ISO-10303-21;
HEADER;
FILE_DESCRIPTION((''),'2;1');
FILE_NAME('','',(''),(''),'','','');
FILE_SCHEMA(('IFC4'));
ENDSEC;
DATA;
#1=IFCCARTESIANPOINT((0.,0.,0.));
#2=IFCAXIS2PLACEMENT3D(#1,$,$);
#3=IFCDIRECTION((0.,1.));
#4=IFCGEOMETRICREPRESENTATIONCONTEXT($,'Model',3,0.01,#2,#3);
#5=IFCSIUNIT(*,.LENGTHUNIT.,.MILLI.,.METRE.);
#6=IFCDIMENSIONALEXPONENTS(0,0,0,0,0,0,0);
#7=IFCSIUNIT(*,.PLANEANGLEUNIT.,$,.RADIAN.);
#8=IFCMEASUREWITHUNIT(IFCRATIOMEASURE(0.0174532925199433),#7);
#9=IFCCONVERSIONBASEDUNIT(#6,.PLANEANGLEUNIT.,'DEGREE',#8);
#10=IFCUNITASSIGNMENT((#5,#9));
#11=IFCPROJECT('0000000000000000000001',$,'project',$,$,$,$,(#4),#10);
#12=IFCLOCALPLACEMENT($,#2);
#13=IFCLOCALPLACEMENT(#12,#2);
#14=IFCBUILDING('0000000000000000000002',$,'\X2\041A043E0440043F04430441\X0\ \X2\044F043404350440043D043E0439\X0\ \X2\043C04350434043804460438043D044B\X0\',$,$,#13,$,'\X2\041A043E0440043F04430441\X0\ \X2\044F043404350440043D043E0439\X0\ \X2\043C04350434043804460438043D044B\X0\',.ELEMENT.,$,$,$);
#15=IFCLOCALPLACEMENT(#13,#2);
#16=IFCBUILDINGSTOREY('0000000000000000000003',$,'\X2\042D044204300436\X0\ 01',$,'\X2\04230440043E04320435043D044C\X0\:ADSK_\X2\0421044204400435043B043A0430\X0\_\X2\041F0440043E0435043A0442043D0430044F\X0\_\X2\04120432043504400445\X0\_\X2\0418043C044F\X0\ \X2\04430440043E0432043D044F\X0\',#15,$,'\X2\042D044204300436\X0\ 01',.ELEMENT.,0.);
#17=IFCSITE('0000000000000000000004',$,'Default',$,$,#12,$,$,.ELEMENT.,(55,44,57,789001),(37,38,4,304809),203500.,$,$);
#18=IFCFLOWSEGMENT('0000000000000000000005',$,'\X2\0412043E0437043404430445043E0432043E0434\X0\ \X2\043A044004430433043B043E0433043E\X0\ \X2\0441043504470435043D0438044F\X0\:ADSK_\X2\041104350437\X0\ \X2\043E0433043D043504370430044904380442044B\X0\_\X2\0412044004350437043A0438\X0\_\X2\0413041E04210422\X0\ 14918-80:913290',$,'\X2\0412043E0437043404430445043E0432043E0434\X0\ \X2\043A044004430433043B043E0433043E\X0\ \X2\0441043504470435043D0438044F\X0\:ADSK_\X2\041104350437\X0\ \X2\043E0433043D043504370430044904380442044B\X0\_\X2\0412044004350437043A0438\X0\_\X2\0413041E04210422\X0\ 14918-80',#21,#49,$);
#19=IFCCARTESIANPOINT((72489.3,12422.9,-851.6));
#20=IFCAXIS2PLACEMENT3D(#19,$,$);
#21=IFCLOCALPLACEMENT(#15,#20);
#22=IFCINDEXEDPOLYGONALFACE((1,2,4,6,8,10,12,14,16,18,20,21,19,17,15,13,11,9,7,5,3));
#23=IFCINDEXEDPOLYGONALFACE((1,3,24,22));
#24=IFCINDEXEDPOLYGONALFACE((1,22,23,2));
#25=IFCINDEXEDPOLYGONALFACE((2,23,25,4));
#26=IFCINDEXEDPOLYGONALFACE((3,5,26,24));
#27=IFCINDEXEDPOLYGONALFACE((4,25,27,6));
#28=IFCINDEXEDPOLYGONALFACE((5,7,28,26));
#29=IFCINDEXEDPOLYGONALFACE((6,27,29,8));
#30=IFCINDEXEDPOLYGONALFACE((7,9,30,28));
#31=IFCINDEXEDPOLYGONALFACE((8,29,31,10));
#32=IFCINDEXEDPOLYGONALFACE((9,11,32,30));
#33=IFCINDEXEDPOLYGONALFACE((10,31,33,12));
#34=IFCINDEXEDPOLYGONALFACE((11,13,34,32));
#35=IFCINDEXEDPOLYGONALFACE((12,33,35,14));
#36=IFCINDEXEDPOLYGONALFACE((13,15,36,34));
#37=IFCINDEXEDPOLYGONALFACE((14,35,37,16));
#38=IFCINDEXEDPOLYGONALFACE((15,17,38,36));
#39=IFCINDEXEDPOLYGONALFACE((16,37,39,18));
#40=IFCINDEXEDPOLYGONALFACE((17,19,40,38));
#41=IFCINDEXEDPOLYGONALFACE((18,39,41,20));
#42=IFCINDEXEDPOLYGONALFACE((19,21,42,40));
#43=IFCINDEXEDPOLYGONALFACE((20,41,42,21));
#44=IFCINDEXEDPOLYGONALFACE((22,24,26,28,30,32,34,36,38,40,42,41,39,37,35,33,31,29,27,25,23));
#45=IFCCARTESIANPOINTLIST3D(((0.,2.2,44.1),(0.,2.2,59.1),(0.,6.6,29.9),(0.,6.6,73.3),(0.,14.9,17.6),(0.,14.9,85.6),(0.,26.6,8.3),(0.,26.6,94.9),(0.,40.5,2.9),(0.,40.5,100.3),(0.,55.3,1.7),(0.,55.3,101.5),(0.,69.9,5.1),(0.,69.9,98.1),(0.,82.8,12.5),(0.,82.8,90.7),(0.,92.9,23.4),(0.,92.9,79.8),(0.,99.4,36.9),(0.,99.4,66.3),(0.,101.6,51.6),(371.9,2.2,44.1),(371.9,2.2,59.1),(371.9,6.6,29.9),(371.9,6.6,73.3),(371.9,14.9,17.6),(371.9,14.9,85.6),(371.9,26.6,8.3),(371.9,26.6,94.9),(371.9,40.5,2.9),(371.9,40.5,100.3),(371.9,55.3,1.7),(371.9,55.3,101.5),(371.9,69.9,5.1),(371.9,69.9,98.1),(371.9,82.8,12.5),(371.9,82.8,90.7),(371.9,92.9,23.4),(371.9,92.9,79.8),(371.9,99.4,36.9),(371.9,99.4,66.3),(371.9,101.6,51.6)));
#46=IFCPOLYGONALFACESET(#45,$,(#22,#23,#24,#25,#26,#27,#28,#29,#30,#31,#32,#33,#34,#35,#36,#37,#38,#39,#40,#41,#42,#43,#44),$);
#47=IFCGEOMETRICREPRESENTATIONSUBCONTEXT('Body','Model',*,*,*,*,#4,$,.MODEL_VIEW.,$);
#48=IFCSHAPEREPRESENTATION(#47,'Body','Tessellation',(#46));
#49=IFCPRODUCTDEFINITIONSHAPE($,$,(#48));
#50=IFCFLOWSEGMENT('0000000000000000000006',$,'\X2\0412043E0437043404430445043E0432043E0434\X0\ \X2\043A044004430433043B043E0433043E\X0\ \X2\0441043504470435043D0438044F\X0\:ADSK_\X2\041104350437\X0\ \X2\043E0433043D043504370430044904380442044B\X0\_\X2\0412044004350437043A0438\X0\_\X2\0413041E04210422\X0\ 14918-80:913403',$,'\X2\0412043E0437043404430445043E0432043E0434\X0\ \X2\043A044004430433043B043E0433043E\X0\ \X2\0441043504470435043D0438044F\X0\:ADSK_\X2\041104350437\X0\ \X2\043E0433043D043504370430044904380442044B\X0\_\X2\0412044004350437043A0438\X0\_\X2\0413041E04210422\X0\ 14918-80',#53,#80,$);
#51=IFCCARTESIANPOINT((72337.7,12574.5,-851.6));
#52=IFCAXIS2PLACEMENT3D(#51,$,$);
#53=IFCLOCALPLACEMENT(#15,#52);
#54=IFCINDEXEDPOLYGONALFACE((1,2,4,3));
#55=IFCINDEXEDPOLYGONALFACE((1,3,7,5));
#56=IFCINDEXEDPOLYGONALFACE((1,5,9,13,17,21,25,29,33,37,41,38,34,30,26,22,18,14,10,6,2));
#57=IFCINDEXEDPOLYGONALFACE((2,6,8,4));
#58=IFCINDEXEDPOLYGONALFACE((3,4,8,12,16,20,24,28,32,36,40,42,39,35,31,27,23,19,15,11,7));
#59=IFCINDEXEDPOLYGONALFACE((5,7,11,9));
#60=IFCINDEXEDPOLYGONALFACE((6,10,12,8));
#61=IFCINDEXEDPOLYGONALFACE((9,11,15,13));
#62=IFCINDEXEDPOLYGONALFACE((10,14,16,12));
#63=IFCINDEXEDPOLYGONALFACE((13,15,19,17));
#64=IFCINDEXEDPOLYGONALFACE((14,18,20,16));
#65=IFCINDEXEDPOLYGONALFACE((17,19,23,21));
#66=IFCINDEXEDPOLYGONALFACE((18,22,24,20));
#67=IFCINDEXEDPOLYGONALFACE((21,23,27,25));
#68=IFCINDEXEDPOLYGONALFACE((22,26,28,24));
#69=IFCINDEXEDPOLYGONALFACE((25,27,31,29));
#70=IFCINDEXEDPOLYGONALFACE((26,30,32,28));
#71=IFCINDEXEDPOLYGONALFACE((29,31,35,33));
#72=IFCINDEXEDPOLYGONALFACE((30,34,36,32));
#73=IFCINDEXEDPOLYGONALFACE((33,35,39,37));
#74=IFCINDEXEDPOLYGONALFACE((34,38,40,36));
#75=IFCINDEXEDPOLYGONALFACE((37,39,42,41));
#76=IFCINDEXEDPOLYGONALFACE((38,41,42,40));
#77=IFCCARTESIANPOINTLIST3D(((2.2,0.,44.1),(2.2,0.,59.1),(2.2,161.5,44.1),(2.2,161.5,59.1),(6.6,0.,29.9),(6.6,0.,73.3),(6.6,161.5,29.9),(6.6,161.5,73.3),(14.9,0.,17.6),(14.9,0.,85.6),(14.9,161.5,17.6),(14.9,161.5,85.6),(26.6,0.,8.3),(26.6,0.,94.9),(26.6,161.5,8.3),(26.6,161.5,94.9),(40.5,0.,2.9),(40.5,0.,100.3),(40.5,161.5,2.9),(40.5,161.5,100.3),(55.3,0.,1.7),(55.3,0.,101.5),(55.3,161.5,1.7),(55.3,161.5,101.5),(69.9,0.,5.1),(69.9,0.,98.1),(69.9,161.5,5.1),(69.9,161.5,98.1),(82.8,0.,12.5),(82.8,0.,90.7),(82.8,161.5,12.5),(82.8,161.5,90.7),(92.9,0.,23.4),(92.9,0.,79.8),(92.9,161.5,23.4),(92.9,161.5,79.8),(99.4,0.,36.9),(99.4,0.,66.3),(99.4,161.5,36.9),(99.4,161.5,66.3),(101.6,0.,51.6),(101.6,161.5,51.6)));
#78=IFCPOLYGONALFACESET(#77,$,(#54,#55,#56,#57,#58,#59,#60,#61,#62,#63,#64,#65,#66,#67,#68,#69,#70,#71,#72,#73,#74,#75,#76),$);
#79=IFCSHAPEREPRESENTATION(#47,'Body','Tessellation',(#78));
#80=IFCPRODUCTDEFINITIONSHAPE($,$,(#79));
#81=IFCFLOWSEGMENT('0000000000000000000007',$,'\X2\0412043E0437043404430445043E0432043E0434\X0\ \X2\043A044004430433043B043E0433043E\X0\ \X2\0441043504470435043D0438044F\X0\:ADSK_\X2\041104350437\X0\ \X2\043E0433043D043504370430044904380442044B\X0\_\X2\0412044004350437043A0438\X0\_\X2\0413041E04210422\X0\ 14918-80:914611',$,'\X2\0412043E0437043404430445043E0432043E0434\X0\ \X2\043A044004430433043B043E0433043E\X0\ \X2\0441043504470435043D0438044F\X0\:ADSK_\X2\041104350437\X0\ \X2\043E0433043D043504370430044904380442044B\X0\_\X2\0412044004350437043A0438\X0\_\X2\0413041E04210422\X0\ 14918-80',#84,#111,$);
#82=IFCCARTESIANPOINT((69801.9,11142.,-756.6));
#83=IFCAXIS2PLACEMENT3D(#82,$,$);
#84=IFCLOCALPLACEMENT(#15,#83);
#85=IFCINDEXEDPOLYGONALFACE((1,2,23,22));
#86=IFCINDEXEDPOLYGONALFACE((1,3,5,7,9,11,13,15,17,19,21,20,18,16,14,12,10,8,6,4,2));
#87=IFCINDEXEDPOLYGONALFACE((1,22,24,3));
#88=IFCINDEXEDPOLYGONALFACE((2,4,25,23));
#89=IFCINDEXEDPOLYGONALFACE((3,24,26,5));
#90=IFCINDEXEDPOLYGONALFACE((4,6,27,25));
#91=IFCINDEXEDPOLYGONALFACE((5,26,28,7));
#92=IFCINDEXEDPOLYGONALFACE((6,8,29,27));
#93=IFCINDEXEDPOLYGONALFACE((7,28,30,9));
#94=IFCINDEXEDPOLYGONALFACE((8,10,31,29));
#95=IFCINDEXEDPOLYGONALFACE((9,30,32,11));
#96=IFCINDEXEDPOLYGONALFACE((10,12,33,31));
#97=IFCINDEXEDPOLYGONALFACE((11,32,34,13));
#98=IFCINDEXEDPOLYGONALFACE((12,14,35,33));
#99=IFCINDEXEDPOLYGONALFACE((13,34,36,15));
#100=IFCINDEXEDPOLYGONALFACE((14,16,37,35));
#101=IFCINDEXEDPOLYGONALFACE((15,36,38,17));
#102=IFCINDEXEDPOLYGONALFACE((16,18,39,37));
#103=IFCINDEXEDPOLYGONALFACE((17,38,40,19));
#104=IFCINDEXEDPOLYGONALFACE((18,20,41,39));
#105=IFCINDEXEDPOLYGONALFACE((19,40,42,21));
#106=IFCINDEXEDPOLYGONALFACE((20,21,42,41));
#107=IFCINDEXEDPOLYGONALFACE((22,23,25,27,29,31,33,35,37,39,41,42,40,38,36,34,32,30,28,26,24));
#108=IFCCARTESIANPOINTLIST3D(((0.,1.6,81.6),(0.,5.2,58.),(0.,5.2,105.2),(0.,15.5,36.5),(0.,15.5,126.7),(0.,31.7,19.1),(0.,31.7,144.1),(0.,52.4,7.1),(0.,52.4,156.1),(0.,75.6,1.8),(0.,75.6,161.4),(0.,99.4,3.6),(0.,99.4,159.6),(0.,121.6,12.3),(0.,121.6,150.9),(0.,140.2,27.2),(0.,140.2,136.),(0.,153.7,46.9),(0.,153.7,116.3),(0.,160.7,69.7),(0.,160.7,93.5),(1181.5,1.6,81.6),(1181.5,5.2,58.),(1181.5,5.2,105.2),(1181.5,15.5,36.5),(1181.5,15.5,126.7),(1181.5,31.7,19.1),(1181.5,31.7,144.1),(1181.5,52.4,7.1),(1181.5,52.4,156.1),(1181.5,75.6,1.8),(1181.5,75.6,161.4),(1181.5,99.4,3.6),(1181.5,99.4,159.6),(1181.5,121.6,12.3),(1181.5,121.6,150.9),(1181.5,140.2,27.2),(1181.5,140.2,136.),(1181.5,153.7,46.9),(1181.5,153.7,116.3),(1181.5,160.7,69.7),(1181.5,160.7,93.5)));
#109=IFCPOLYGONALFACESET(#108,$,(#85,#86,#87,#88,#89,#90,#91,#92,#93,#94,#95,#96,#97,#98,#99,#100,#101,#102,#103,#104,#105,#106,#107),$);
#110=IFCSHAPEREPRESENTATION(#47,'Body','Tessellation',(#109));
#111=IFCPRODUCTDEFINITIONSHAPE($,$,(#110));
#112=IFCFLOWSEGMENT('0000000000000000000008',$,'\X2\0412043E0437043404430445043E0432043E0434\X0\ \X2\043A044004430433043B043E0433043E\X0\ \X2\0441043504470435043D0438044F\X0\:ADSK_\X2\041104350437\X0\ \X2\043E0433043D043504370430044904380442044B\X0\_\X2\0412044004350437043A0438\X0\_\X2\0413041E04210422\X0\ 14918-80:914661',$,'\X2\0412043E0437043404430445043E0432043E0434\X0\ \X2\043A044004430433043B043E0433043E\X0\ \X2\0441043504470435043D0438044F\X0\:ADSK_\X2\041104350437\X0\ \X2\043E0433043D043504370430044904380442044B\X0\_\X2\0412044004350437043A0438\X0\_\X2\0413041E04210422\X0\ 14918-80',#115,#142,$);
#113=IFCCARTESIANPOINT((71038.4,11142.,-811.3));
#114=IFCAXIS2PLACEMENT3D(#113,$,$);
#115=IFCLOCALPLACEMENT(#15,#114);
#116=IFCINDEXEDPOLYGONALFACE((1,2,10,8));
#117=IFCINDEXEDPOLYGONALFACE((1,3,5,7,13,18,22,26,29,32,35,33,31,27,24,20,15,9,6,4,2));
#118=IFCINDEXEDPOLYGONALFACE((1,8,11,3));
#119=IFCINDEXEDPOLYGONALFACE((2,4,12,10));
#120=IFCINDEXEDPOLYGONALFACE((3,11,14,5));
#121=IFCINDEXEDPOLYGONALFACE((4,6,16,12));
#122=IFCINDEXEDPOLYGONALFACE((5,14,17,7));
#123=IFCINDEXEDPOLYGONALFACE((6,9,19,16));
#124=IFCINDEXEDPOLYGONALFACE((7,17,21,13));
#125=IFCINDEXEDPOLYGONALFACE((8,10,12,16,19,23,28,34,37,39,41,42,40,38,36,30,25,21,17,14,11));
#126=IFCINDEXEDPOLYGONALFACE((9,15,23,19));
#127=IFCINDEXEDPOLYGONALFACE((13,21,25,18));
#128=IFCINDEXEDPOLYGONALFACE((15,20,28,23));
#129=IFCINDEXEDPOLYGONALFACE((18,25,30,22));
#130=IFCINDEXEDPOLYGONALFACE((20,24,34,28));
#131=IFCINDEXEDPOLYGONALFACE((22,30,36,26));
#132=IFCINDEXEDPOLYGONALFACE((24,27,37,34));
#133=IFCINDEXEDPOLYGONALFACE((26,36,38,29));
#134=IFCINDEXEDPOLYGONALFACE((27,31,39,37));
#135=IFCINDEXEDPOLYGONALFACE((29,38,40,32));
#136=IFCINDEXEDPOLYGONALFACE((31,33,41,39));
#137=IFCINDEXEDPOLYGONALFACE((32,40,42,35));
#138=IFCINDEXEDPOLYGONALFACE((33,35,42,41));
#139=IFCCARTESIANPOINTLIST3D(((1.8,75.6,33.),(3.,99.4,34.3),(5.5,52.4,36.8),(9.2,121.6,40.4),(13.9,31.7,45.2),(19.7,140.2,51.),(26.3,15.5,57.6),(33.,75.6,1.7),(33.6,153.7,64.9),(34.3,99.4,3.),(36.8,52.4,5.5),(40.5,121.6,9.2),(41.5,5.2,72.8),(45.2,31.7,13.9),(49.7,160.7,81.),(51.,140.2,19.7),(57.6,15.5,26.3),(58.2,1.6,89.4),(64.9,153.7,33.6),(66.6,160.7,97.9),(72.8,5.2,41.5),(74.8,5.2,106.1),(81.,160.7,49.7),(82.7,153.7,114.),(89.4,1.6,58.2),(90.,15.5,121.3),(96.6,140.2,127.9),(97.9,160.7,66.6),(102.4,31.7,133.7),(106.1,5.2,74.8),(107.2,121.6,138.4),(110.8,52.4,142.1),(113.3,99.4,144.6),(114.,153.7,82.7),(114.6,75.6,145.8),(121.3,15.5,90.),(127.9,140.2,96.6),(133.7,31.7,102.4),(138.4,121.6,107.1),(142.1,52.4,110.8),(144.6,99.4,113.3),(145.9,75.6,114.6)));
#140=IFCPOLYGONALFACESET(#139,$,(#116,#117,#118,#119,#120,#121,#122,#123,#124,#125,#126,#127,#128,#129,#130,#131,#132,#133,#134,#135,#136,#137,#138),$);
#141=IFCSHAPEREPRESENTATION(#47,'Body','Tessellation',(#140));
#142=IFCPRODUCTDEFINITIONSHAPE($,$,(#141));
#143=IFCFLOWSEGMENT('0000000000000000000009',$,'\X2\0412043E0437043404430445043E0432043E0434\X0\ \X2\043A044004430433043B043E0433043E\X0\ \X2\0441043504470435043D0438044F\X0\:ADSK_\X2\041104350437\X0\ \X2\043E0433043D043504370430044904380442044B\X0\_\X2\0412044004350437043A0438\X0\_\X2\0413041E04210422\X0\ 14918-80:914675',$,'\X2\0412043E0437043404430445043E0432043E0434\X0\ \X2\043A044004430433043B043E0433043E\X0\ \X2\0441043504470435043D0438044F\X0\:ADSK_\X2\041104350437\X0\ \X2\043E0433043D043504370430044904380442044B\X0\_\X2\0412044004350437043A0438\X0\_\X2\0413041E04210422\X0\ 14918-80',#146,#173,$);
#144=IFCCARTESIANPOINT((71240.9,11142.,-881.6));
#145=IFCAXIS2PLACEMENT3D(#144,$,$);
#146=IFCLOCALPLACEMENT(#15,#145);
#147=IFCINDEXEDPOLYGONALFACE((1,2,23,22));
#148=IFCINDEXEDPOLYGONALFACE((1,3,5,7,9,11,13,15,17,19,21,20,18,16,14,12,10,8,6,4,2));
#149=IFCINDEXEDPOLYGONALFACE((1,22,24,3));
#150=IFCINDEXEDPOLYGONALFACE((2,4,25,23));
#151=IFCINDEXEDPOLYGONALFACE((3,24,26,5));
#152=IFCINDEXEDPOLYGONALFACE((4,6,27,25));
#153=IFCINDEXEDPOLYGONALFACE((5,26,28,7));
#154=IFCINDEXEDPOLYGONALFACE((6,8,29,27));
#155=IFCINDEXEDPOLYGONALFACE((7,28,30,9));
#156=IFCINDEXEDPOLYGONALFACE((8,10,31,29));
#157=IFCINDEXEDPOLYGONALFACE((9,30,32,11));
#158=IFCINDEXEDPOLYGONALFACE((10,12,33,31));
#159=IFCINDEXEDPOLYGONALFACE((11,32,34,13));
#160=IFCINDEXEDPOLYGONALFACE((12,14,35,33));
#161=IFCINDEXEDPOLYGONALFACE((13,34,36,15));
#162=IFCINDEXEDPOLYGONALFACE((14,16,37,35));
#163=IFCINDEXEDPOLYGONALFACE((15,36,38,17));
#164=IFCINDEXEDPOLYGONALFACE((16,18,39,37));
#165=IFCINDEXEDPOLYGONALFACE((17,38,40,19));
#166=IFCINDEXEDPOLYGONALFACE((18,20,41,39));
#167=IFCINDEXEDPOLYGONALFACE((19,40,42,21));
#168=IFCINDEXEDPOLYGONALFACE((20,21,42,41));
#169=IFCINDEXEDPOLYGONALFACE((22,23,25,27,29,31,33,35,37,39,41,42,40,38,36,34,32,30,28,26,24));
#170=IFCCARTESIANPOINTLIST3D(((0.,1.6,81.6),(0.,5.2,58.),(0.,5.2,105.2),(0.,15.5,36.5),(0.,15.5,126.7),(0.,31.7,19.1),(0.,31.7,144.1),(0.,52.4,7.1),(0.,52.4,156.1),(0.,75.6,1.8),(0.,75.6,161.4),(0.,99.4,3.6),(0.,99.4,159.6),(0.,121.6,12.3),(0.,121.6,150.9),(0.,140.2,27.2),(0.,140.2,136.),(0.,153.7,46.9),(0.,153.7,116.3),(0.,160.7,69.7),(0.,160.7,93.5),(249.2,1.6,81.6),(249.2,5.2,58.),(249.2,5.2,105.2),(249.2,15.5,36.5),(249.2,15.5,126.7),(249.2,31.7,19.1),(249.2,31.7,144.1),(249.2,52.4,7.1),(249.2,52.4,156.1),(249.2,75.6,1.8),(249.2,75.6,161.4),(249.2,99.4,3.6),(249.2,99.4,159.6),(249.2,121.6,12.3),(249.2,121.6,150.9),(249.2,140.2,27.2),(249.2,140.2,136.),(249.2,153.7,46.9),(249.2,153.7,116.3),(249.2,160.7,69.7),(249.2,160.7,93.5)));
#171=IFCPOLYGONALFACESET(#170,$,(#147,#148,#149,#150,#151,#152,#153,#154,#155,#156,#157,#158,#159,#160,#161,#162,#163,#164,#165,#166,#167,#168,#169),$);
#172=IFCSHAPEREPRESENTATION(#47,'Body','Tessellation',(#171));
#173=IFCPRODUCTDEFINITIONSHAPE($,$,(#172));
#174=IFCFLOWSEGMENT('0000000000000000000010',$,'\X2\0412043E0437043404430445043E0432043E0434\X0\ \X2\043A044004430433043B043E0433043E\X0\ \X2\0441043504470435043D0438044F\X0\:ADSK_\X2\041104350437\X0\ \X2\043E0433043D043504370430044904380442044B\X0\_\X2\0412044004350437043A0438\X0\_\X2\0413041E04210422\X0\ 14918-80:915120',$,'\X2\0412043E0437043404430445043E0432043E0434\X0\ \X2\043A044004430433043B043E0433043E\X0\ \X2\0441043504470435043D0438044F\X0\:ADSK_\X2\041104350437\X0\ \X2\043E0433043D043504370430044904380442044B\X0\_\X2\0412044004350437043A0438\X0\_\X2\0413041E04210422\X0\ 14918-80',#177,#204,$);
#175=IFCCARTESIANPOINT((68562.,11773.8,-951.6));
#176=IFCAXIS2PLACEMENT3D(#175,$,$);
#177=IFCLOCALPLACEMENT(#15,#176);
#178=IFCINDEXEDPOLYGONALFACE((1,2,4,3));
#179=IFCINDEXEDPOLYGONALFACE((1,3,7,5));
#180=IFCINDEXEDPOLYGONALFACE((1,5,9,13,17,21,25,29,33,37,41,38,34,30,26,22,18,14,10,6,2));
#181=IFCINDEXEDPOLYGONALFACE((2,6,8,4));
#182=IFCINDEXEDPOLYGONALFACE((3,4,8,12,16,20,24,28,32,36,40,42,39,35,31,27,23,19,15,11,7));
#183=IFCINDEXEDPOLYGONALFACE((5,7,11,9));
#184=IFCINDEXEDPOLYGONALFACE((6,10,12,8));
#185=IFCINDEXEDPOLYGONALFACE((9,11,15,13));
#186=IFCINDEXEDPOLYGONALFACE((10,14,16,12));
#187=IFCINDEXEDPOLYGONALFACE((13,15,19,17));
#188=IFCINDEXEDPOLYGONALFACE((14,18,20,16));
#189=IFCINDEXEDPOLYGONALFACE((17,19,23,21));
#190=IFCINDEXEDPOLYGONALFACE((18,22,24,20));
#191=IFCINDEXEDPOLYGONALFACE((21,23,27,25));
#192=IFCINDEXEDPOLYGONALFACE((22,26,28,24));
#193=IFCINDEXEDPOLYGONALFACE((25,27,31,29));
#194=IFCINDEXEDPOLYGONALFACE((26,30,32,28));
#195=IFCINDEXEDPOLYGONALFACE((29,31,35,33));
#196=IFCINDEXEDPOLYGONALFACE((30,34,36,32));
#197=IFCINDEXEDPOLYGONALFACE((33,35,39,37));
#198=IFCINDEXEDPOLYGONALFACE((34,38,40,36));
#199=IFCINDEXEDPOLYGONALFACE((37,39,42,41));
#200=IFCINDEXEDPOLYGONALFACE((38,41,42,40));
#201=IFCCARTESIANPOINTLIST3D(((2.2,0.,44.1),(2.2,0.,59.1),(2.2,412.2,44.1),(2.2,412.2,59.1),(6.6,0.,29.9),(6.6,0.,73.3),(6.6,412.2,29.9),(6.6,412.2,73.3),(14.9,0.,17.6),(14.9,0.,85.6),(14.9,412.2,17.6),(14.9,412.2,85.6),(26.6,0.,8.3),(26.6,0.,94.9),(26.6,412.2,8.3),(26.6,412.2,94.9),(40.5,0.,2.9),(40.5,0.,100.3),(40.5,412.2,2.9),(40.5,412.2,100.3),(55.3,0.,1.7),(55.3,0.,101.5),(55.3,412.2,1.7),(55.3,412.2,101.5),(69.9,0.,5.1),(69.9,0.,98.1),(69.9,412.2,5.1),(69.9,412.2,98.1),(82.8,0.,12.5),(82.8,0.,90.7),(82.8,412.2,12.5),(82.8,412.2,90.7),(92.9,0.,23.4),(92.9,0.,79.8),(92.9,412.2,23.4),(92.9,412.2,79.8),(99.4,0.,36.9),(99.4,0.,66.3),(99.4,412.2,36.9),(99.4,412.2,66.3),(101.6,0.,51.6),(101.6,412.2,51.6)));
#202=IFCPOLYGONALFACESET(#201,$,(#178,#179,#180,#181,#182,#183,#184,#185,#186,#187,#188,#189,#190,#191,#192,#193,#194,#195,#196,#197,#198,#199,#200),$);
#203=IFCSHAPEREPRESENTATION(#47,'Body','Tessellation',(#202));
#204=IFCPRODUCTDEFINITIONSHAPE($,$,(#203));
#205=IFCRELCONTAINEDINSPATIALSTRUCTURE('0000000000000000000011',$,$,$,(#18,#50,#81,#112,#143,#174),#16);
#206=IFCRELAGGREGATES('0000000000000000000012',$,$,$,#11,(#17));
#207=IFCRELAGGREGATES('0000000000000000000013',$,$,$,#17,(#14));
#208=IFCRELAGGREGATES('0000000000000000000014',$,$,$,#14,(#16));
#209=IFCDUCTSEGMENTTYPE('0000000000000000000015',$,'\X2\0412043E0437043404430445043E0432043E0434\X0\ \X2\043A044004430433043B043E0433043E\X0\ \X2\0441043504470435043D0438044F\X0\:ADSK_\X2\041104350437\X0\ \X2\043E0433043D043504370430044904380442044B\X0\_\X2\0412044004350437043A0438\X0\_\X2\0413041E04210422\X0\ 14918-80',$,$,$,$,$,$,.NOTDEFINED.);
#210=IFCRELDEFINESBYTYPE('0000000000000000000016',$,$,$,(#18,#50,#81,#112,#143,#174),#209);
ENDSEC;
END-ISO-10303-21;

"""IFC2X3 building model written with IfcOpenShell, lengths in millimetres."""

from ifc_helpers import new_model, entity, si_unit, converted_unit, direction, frame, origin, origin_2d_with_axis, place, context, subcontext, project, spatial, circle, extrude, type_object, element, save


model = new_model("IFC2X3")

# Units and contexts
model_context = context("Model", 3, precision=0.01, world=origin(), true_north=direction((0.0, 1.0)))
body_context = subcontext(model_context, "Body", "Model", "MODEL_VIEW")
ifc_project = project(units=[si_unit("LENGTHUNIT", "METRE", prefix="MILLI"), converted_unit("PLANEANGLEUNIT", "DEGREE", entity("IfcRatioMeasure", 0.0174532925199433), si_unit("PLANEANGLEUNIT", "RADIAN"), dimensions=[0, 0, 0, 0, 0, 0, 0])], contexts=[model_context])

# Site, building, storey
site_placement = place(None, origin())
site = spatial("IfcSite", under=ifc_project, at=site_placement, Name="Default", CompositionType="ELEMENT", RefLatitude=(55, 44, 57, 789001), RefLongitude=(37, 38, 4, 304809), RefElevation=203500.0)
building_placement = place(site_placement, origin())
building = spatial("IfcBuilding", under=site, at=building_placement, Name="Корпус ядерной медицины", LongName="Корпус ядерной медицины", CompositionType="ELEMENT")
storey_placement = place(building_placement, origin())
storey = spatial("IfcBuildingStorey", under=building, at=storey_placement, Name="Этаж 01", ObjectType="Уровень:ADSK_Стрелка_Проектная_Вверх_Имя уровня", LongName="Этаж 01", CompositionType="ELEMENT", Elevation=0.0)

# Flow segments
duct_segment_type_1 = type_object("IfcDuctSegmentType", Name="Воздуховод круглого сечения:ADSK_Без огнезащиты_Врезки_ГОСТ 14918-80", PredefinedType="NOTDEFINED")
flow_segment_1_placement = place(storey_placement, frame((72489.3, 12422.9, -851.6)))
element("IfcFlowSegment", 1, at=flow_segment_1_placement, inside=storey, type_object=duct_segment_type_1, Name="Воздуховод круглого сечения:ADSK_Без огнезащиты_Врезки_ГОСТ 14918-80:913290", ObjectType="Воздуховод круглого сечения:ADSK_Без огнезащиты_Врезки_ГОСТ 14918-80", context=body_context, shape_type="SweptSolid", body=[
    extrude(circle(Radius=50.0, at=origin_2d_with_axis()), frame((0.0, 51.6, 51.6), z_axis=(1.0, 0.0, 0.0), x_axis=(0.0, 1.0, 0.0)), (0.0, 0.0, 1.0), 371.9),
])
flow_segment_2_placement = place(storey_placement, frame((72337.7, 12574.5, -851.6)))
element("IfcFlowSegment", 2, at=flow_segment_2_placement, inside=storey, type_object=duct_segment_type_1, Name="Воздуховод круглого сечения:ADSK_Без огнезащиты_Врезки_ГОСТ 14918-80:913403", ObjectType="Воздуховод круглого сечения:ADSK_Без огнезащиты_Врезки_ГОСТ 14918-80", context=body_context, shape_type="SweptSolid", body=[
    extrude(circle(Radius=50.0, at=origin_2d_with_axis()), frame((51.6, 0.0, 51.6), z_axis=(0.0, 1.0, 0.0), x_axis=(1.0, 0.0, 0.0)), (0.0, 0.0, 1.0), 161.5),
])
flow_segment_3_placement = place(storey_placement, frame((69801.9, 11142.0, -756.6)))
element("IfcFlowSegment", 3, at=flow_segment_3_placement, inside=storey, type_object=duct_segment_type_1, Name="Воздуховод круглого сечения:ADSK_Без огнезащиты_Врезки_ГОСТ 14918-80:914611", ObjectType="Воздуховод круглого сечения:ADSK_Без огнезащиты_Врезки_ГОСТ 14918-80", context=body_context, shape_type="SweptSolid", body=[
    extrude(circle(Radius=80.0, at=origin_2d_with_axis()), frame((0.0, 81.6, 81.6), z_axis=(1.0, 0.0, 0.0), x_axis=(0.0, -1.0, 0.0)), (0.0, 0.0, 1.0), 1181.5),
])
flow_segment_4_placement = place(storey_placement, frame((71038.4, 11142.0, -811.3)))
element("IfcFlowSegment", 4, at=flow_segment_4_placement, inside=storey, type_object=duct_segment_type_1, Name="Воздуховод круглого сечения:ADSK_Без огнезащиты_Врезки_ГОСТ 14918-80:914661", ObjectType="Воздуховод круглого сечения:ADSK_Без огнезащиты_Врезки_ГОСТ 14918-80", context=body_context, shape_type="SweptSolid", body=[
    extrude(circle(Radius=80.0, at=origin_2d_with_axis()), frame((89.4, 81.6, 58.2), z_axis=(-0.707107, 0.0, 0.707107), x_axis=(0.0, -1.0, 0.0)), (0.0, 0.0, 1.0), 44.2),
])
flow_segment_5_placement = place(storey_placement, frame((71240.9, 11142.0, -881.6)))
element("IfcFlowSegment", 5, at=flow_segment_5_placement, inside=storey, type_object=duct_segment_type_1, Name="Воздуховод круглого сечения:ADSK_Без огнезащиты_Врезки_ГОСТ 14918-80:914675", ObjectType="Воздуховод круглого сечения:ADSK_Без огнезащиты_Врезки_ГОСТ 14918-80", context=body_context, shape_type="SweptSolid", body=[
    extrude(circle(Radius=80.0, at=origin_2d_with_axis()), frame((0.0, 81.6, 81.6), z_axis=(1.0, 0.0, 0.0), x_axis=(0.0, -1.0, 0.0)), (0.0, 0.0, 1.0), 249.2),
])
flow_segment_6_placement = place(storey_placement, frame((68562.0, 11773.8, -951.6)))
element("IfcFlowSegment", 6, at=flow_segment_6_placement, inside=storey, type_object=duct_segment_type_1, Name="Воздуховод круглого сечения:ADSK_Без огнезащиты_Врезки_ГОСТ 14918-80:915120", ObjectType="Воздуховод круглого сечения:ADSK_Без огнезащиты_Врезки_ГОСТ 14918-80", context=body_context, shape_type="SweptSolid", body=[
    extrude(circle(Radius=50.0, at=origin_2d_with_axis()), frame((51.6, 0.0, 51.6), z_axis=(0.0, 1.0, 0.0), x_axis=(1.0, 0.0, 0.0)), (0.0, 0.0, 1.0), 412.2),
])

save(model, "model.ifc")
